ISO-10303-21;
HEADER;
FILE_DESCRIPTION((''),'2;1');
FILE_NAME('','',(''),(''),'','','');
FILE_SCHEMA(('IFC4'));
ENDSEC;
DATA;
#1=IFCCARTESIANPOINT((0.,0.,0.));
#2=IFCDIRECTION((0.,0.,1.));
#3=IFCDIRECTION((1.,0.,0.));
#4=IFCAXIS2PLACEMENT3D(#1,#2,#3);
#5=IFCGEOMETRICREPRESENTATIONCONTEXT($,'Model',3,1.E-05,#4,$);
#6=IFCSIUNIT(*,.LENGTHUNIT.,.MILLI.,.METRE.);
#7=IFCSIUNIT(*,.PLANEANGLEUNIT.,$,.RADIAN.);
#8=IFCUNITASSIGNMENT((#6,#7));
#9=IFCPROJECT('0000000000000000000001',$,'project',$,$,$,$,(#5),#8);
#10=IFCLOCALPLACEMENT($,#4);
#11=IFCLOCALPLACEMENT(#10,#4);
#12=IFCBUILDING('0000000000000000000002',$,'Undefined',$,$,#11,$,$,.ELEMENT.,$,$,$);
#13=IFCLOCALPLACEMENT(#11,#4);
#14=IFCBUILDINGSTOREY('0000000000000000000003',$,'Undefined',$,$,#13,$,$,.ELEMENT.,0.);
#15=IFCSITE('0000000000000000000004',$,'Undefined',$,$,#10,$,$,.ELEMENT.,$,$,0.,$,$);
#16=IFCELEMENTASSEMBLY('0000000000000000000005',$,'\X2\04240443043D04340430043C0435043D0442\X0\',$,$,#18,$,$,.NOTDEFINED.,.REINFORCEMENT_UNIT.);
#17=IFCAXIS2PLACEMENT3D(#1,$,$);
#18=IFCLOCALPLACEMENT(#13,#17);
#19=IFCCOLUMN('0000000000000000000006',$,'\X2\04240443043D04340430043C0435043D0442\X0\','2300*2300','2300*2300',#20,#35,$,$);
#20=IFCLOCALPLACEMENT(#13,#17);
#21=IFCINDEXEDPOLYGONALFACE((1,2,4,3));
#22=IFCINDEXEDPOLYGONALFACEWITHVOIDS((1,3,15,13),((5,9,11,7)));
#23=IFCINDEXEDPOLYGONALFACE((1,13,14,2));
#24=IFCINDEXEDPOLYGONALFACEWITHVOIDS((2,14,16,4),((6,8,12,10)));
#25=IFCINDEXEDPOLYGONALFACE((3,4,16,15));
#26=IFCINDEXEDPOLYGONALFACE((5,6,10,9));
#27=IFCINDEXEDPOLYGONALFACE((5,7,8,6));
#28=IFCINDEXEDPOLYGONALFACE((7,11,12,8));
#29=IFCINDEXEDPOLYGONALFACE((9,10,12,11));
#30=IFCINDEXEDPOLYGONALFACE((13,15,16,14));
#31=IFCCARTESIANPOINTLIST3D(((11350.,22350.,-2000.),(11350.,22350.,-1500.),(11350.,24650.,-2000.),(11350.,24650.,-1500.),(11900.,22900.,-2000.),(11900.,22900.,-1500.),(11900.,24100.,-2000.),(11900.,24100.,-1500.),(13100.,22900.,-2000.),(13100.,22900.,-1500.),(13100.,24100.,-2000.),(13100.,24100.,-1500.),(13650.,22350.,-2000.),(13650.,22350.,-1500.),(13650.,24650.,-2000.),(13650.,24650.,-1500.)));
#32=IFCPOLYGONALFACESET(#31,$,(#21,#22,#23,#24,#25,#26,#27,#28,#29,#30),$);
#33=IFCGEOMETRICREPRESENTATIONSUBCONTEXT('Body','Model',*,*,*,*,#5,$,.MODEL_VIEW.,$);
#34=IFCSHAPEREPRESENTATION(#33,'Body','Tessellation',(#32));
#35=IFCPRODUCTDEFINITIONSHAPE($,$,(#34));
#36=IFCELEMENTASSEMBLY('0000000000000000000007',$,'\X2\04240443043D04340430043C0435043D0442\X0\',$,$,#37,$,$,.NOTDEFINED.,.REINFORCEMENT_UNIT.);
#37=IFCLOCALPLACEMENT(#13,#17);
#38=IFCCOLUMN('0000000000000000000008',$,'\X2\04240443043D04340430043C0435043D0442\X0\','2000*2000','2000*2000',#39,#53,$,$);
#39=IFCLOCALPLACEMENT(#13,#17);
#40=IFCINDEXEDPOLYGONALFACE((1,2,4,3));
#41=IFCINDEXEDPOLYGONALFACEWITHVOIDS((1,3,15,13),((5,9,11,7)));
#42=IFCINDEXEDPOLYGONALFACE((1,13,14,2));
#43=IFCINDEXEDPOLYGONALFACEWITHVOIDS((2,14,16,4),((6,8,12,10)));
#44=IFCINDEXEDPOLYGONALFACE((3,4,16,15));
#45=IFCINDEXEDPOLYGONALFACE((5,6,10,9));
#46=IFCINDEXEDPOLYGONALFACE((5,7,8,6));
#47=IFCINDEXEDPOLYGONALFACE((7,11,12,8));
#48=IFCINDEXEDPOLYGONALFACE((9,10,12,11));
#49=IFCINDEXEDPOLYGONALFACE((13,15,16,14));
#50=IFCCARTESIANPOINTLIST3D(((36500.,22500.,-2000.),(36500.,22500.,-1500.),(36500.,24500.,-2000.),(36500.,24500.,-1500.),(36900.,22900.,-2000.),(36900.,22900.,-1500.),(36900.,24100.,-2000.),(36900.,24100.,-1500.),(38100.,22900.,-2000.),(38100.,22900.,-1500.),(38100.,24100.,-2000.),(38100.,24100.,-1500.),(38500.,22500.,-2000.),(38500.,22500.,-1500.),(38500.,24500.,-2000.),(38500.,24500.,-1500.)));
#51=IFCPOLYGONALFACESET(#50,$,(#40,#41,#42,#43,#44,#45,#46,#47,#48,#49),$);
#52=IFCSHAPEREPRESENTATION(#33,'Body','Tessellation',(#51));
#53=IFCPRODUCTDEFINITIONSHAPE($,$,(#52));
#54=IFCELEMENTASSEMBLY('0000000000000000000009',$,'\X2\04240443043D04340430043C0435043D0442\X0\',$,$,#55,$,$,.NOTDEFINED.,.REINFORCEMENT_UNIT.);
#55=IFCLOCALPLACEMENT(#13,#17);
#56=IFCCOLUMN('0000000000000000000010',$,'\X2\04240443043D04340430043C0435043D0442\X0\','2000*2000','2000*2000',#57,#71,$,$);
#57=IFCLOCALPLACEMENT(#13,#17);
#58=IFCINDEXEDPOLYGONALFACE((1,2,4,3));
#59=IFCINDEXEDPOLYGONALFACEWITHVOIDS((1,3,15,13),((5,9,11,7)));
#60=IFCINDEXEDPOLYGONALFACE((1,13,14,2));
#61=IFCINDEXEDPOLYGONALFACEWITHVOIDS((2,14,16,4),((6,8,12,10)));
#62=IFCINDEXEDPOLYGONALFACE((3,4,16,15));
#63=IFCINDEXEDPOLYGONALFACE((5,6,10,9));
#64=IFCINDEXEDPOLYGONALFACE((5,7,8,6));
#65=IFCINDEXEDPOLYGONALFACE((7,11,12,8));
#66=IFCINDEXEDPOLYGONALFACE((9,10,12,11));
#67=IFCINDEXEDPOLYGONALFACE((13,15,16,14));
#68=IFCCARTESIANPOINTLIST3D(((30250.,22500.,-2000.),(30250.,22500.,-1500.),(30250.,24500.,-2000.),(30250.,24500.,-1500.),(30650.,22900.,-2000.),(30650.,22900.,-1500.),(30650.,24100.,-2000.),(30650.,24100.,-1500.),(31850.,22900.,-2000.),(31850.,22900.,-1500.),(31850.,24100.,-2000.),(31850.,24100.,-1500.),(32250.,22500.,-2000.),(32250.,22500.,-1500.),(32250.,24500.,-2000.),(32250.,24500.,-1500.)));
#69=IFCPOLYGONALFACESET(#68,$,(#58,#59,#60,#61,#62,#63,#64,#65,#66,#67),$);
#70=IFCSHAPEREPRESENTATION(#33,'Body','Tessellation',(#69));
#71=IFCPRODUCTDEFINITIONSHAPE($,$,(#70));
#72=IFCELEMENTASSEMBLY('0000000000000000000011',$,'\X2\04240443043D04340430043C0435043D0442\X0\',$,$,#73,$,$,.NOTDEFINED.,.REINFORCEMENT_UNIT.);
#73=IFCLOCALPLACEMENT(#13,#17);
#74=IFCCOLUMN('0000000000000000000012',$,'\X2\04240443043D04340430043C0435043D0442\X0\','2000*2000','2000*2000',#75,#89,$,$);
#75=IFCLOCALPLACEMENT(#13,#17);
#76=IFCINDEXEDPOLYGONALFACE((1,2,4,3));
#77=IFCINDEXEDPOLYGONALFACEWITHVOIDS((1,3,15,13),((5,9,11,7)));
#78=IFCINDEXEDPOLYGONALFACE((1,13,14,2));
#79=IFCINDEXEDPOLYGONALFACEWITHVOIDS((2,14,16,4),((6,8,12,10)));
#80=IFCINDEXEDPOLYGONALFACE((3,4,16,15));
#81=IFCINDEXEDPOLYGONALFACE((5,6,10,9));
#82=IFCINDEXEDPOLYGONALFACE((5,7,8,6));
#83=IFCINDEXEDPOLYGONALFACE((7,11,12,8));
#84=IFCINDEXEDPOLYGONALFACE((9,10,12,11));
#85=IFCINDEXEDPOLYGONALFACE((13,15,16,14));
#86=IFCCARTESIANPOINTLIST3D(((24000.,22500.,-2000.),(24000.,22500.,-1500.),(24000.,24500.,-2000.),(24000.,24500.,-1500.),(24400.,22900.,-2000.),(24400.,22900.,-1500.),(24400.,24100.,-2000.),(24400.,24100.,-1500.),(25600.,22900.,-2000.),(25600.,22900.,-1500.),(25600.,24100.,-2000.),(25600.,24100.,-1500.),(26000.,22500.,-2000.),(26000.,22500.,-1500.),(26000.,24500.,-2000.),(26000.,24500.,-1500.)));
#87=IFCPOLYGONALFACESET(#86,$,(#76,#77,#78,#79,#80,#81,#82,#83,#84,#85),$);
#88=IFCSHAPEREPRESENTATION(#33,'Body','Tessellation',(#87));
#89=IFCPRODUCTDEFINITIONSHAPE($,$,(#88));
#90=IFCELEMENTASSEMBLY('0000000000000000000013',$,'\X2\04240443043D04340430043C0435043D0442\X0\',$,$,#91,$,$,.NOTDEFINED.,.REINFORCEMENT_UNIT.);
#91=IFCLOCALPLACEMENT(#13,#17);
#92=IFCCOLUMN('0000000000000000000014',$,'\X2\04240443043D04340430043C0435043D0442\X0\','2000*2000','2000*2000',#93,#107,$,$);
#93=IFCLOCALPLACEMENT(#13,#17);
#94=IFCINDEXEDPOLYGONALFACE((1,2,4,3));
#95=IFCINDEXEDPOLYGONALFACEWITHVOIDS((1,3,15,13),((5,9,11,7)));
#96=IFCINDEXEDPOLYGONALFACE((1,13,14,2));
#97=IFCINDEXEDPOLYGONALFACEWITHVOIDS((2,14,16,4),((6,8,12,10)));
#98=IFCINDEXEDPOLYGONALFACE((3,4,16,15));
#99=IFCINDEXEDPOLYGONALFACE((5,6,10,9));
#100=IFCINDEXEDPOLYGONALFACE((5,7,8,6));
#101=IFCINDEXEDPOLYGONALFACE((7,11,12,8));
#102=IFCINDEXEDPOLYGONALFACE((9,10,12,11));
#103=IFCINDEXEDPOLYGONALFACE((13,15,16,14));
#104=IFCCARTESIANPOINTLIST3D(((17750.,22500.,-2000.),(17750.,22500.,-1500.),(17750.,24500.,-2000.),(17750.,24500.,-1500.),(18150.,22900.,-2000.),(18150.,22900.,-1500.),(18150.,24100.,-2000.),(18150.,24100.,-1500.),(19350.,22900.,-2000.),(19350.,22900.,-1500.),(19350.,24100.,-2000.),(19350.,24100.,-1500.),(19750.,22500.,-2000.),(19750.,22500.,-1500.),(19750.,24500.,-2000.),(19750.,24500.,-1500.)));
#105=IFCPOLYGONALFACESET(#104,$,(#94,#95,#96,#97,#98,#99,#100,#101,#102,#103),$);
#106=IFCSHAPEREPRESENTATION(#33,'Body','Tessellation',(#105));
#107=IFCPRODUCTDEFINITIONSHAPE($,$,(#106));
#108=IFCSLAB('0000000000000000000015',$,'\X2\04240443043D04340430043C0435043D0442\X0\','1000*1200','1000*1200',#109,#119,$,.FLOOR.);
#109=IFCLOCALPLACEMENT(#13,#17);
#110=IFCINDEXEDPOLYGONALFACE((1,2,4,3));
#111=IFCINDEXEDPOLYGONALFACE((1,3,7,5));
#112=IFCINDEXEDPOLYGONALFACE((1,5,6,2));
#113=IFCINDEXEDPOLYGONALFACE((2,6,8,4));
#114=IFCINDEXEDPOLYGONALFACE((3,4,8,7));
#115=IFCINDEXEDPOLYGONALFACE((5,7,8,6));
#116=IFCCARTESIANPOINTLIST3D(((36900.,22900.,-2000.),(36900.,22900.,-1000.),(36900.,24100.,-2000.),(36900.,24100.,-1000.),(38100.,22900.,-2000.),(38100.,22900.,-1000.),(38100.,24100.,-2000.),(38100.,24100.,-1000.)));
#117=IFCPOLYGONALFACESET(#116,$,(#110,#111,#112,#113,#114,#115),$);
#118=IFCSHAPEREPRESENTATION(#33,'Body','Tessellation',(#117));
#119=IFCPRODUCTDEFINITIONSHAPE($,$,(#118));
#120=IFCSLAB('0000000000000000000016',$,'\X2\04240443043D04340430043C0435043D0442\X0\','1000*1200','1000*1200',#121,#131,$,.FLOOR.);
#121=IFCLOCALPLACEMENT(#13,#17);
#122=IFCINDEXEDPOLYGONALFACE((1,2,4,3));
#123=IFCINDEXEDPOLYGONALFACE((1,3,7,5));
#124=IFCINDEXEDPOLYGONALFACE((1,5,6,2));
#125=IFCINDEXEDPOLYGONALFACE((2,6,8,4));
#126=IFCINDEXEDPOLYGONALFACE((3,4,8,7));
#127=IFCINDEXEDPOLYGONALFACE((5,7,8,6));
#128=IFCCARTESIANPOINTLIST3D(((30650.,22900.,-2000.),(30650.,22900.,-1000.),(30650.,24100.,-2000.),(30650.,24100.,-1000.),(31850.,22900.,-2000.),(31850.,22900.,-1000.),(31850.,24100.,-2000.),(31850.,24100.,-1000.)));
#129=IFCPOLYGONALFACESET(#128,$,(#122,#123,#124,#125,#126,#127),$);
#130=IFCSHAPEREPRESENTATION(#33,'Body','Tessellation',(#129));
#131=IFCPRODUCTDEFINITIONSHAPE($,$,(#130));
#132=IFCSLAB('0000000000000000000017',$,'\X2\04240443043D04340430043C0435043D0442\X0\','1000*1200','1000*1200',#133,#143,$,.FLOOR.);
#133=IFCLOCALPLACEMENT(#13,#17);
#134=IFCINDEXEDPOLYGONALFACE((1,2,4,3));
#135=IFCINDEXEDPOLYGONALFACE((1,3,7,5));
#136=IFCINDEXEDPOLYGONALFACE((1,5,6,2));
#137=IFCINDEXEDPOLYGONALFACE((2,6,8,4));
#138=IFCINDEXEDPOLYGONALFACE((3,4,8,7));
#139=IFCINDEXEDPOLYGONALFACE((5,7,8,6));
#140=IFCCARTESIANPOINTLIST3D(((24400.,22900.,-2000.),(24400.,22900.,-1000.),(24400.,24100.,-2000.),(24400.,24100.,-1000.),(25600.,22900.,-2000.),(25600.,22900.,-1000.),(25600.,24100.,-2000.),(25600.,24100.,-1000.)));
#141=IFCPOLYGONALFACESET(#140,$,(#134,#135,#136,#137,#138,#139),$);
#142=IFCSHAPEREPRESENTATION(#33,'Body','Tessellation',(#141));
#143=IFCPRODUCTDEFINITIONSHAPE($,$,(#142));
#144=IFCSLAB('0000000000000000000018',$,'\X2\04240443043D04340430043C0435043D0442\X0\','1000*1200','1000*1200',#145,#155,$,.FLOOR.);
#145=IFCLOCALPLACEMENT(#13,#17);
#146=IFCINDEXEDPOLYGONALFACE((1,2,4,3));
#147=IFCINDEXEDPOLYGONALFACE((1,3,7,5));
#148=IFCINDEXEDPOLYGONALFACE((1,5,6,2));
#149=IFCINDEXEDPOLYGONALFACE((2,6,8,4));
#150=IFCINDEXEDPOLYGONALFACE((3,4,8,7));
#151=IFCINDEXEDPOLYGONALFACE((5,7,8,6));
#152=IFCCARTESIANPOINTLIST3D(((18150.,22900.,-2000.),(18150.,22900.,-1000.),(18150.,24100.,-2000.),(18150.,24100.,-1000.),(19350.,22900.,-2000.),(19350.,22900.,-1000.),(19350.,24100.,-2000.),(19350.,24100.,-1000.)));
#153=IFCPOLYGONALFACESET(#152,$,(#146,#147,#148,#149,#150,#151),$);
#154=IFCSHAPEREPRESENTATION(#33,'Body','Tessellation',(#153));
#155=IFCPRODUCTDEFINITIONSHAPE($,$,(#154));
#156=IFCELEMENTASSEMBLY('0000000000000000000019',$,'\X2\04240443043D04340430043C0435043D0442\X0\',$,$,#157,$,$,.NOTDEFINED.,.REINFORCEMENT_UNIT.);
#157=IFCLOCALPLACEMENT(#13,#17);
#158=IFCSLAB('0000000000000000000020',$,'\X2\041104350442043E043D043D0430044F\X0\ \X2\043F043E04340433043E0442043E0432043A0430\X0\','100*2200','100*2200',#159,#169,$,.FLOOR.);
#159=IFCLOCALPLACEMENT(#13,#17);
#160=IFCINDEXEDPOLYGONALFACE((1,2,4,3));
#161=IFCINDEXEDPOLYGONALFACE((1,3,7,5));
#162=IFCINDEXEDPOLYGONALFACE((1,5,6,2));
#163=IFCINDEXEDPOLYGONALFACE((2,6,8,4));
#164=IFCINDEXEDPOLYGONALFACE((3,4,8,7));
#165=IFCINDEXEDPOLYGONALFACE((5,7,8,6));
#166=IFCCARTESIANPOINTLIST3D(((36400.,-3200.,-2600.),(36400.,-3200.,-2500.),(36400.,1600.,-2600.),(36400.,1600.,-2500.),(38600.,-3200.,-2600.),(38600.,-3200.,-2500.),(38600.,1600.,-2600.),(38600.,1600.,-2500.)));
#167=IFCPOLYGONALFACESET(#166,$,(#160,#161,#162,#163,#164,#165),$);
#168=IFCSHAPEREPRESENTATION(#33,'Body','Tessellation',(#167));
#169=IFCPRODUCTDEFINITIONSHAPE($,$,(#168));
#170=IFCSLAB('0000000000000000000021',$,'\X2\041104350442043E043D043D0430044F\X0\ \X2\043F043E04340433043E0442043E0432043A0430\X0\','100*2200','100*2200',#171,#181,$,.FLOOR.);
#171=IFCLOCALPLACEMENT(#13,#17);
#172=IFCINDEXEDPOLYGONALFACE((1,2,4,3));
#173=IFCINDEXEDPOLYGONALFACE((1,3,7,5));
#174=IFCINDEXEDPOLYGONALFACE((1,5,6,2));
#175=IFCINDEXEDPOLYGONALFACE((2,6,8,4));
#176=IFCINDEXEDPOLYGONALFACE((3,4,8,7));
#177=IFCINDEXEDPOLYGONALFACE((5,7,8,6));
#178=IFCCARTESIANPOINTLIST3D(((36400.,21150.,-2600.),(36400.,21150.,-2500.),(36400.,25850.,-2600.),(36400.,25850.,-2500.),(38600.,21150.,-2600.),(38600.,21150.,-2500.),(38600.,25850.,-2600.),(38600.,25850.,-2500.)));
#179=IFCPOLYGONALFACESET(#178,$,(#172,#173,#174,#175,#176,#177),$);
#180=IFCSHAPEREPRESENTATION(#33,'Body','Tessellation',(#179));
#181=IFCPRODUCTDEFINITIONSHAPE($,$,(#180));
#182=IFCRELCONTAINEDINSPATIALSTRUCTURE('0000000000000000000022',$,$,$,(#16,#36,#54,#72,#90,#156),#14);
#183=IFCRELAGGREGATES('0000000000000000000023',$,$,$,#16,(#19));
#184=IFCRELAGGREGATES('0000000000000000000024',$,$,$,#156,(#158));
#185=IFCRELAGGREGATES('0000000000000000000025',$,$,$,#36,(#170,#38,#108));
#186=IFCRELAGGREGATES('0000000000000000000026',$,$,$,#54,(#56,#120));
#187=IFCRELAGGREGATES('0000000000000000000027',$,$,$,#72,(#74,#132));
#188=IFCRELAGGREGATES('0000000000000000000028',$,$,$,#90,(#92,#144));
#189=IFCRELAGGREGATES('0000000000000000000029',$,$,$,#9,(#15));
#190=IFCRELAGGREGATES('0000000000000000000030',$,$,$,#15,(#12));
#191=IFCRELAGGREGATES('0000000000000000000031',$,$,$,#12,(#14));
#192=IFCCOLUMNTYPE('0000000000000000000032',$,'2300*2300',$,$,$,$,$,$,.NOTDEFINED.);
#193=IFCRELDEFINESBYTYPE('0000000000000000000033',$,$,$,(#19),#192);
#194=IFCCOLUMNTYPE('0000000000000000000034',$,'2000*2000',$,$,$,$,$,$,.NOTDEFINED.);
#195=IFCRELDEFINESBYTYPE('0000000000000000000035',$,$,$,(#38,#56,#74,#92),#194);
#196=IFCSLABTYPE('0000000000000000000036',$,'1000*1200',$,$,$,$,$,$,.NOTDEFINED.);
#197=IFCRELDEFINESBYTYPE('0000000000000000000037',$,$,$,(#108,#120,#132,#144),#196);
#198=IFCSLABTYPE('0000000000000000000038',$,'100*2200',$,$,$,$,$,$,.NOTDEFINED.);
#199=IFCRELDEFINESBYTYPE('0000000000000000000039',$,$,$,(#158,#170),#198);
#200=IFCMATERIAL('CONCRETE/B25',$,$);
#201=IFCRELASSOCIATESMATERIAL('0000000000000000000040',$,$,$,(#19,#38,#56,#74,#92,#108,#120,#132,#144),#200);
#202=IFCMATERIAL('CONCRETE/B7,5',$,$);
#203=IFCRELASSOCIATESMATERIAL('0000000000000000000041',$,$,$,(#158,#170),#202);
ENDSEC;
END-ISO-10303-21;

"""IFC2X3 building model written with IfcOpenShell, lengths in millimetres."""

from ifc_helpers import new_model, si_unit, frame, origin_with_axes, origin_2d_with_axis, place, context, subcontext, project, spatial, polyline, rectangle, outline, extrude, boolean, material, type_object, element, aggregate, save


model = new_model("IFC2X3")

# Units and contexts
model_context = context("Model", 3, precision=1e-05, world=origin_with_axes())
body_context = subcontext(model_context, "Body", "Model", "MODEL_VIEW")
ifc_project = project(units=[si_unit("LENGTHUNIT", "METRE", prefix="MILLI"), si_unit("PLANEANGLEUNIT", "RADIAN")], contexts=[model_context])

# Site, building, storey
site_placement = place(None, origin_with_axes())
site = spatial("IfcSite", under=ifc_project, at=site_placement, Name="Undefined", CompositionType="ELEMENT", RefElevation=0.0)
building_placement = place(site_placement, origin_with_axes())
building = spatial("IfcBuilding", under=site, at=building_placement, Name="Undefined", CompositionType="ELEMENT")
storey_placement = place(building_placement, origin_with_axes())
storey = spatial("IfcBuildingStorey", under=building, at=storey_placement, Name="Undefined", CompositionType="ELEMENT", Elevation=0.0)

# Element assemblies, columns
assembly_1_placement = place(storey_placement, origin_with_axes())
assembly_1 = element("IfcElementAssembly", 1, at=assembly_1_placement, inside=storey, Name="Фундамент", AssemblyPlace="NOTDEFINED", PredefinedType="REINFORCEMENT_UNIT")
ifc_material_1 = material(Name="CONCRETE/B25")
column_type_1 = type_object("IfcColumnType", Name="2300*2300", PredefinedType="NOTDEFINED")
column_1_placement = place(assembly_1_placement, frame((12500.0, 23500.0, -2000.0), z_axis=(0.0, 0.0, 1.0), x_axis=(0.0, -1.0, 0.0)))
column_1 = element("IfcColumn", 2, at=column_1_placement, type_object=column_type_1, material=ifc_material_1, Name="Фундамент", Description="2300*2300", ObjectType="2300*2300", context=body_context, shape_type="CSG", body=[
    boolean("DIFFERENCE", extrude(rectangle(XDim=2300.0, YDim=2300.0, at=origin_2d_with_axis()), frame((0.0, 0.0, 500.0), z_axis=(0.0, 0.0, -1.0), x_axis=(0.0, 1.0, 0.0)), (0.0, 0.0, 1.0), 500.0), extrude(outline(polyline([(0.0, 0.0), (1200.0, 0.0), (1200.0, 1200.0), (0.0, 1200.0), (0.0, 0.0)])), frame((-600.0, -600.0, -100.0), z_axis=(0.0, 0.0, 1.0), x_axis=(1.0, 0.0, 0.0)), (0.0, 0.0, 1.0), 700.0)),
])
aggregate(assembly_1, [column_1])
assembly_2_placement = place(storey_placement, origin_with_axes())
assembly_2 = element("IfcElementAssembly", 3, at=assembly_2_placement, inside=storey, Name="Фундамент", AssemblyPlace="NOTDEFINED", PredefinedType="REINFORCEMENT_UNIT")
column_type_2 = type_object("IfcColumnType", Name="2000*2000", PredefinedType="NOTDEFINED")
column_2_placement = place(assembly_2_placement, frame((37500.0, 23500.0, -2000.0), z_axis=(0.0, 0.0, 1.0), x_axis=(0.0, -1.0, 0.0)))
column_2 = element("IfcColumn", 4, at=column_2_placement, type_object=column_type_2, material=ifc_material_1, Name="Фундамент", Description="2000*2000", ObjectType="2000*2000", context=body_context, shape_type="CSG", body=[
    boolean("DIFFERENCE", extrude(rectangle(XDim=2000.0, YDim=2000.0, at=origin_2d_with_axis()), frame((0.0, 0.0, 500.0), z_axis=(0.0, 0.0, -1.0), x_axis=(0.0, 1.0, 0.0)), (0.0, 0.0, 1.0), 500.0), extrude(outline(polyline([(0.0, 0.0), (1200.0, 0.0), (1200.0, 1200.0), (0.0, 1200.0), (0.0, 0.0)])), frame((-600.0, -600.0, -100.0), z_axis=(0.0, 0.0, 1.0), x_axis=(1.0, 0.0, 0.0)), (0.0, 0.0, 1.0), 700.0)),
])
assembly_3_placement = place(storey_placement, origin_with_axes())
assembly_3 = element("IfcElementAssembly", 5, at=assembly_3_placement, inside=storey, Name="Фундамент", AssemblyPlace="NOTDEFINED", PredefinedType="REINFORCEMENT_UNIT")
column_3_placement = place(assembly_3_placement, frame((31250.0, 23500.0, -2000.0), z_axis=(0.0, 0.0, 1.0), x_axis=(0.0, -1.0, 0.0)))
column_3 = element("IfcColumn", 6, at=column_3_placement, type_object=column_type_2, material=ifc_material_1, Name="Фундамент", Description="2000*2000", ObjectType="2000*2000", context=body_context, shape_type="CSG", body=[
    boolean("DIFFERENCE", extrude(rectangle(XDim=2000.0, YDim=2000.0, at=origin_2d_with_axis()), frame((0.0, 0.0, 500.0), z_axis=(0.0, 0.0, -1.0), x_axis=(0.0, 1.0, 0.0)), (0.0, 0.0, 1.0), 500.0), extrude(outline(polyline([(0.0, 0.0), (1200.0, 0.0), (1200.0, 1200.0), (0.0, 1200.0), (0.0, 0.0)])), frame((-600.0, -600.0, -100.0), z_axis=(0.0, 0.0, 1.0), x_axis=(1.0, 0.0, 0.0)), (0.0, 0.0, 1.0), 700.0)),
])
assembly_4_placement = place(storey_placement, origin_with_axes())
assembly_4 = element("IfcElementAssembly", 7, at=assembly_4_placement, inside=storey, Name="Фундамент", AssemblyPlace="NOTDEFINED", PredefinedType="REINFORCEMENT_UNIT")
column_4_placement = place(assembly_4_placement, frame((25000.0, 23500.0, -2000.0), z_axis=(0.0, 0.0, 1.0), x_axis=(0.0, -1.0, 0.0)))
column_4 = element("IfcColumn", 8, at=column_4_placement, type_object=column_type_2, material=ifc_material_1, Name="Фундамент", Description="2000*2000", ObjectType="2000*2000", context=body_context, shape_type="CSG", body=[
    boolean("DIFFERENCE", extrude(rectangle(XDim=2000.0, YDim=2000.0, at=origin_2d_with_axis()), frame((0.0, 0.0, 500.0), z_axis=(0.0, 0.0, -1.0), x_axis=(0.0, 1.0, 0.0)), (0.0, 0.0, 1.0), 500.0), extrude(outline(polyline([(0.0, 0.0), (1200.0, 0.0), (1200.0, 1200.0), (0.0, 1200.0), (0.0, 0.0)])), frame((-600.0, -600.0, -100.0), z_axis=(0.0, 0.0, 1.0), x_axis=(1.0, 0.0, 0.0)), (0.0, 0.0, 1.0), 700.0)),
])
assembly_5_placement = place(storey_placement, origin_with_axes())
assembly_5 = element("IfcElementAssembly", 9, at=assembly_5_placement, inside=storey, Name="Фундамент", AssemblyPlace="NOTDEFINED", PredefinedType="REINFORCEMENT_UNIT")
column_5_placement = place(assembly_5_placement, frame((18750.0, 23500.0, -2000.0), z_axis=(0.0, 0.0, 1.0), x_axis=(0.0, -1.0, 0.0)))
column_5 = element("IfcColumn", 10, at=column_5_placement, type_object=column_type_2, material=ifc_material_1, Name="Фундамент", Description="2000*2000", ObjectType="2000*2000", context=body_context, shape_type="CSG", body=[
    boolean("DIFFERENCE", extrude(rectangle(XDim=2000.0, YDim=2000.0, at=origin_2d_with_axis()), frame((0.0, 0.0, 500.0), z_axis=(0.0, 0.0, -1.0), x_axis=(0.0, 1.0, 0.0)), (0.0, 0.0, 1.0), 500.0), extrude(outline(polyline([(0.0, 0.0), (1200.0, 0.0), (1200.0, 1200.0), (0.0, 1200.0), (0.0, 0.0)])), frame((-600.0, -600.0, -100.0), z_axis=(0.0, 0.0, 1.0), x_axis=(1.0, 0.0, 0.0)), (0.0, 0.0, 1.0), 700.0)),
])

# Slabs
slab_type_1 = type_object("IfcSlabType", Name="1000*1200", PredefinedType="NOTDEFINED")
slab_1_placement = place(assembly_2_placement, frame((36900.0, 24100.0, -1500.0), z_axis=(0.0, 0.0, 1.0), x_axis=(0.0, -1.0, 0.0)))
slab_1 = element("IfcSlab", 11, at=slab_1_placement, type_object=slab_type_1, material=ifc_material_1, Name="Фундамент", Description="1000*1200", ObjectType="1000*1200", PredefinedType="FLOOR", context=body_context, shape_type="SweptSolid", body=[
    extrude(outline(polyline([(0.0, 0.0), (1200.0, 0.0), (1200.0, 1200.0), (0.0, 1200.0), (0.0, 0.0)])), frame((0.0, 0.0, -500.0), z_axis=(0.0, 0.0, 1.0), x_axis=(1.0, 0.0, 0.0)), (0.0, 0.0, 1.0), 1000.0),
])
slab_2_placement = place(assembly_3_placement, frame((30650.0, 24100.0, -1500.0), z_axis=(0.0, 0.0, 1.0), x_axis=(0.0, -1.0, 0.0)))
slab_2 = element("IfcSlab", 12, at=slab_2_placement, type_object=slab_type_1, material=ifc_material_1, Name="Фундамент", Description="1000*1200", ObjectType="1000*1200", PredefinedType="FLOOR", context=body_context, shape_type="SweptSolid", body=[
    extrude(outline(polyline([(0.0, 0.0), (1200.0, 0.0), (1200.0, 1200.0), (0.0, 1200.0), (0.0, 0.0)])), frame((0.0, 0.0, -500.0), z_axis=(0.0, 0.0, 1.0), x_axis=(1.0, 0.0, 0.0)), (0.0, 0.0, 1.0), 1000.0),
])
slab_3_placement = place(assembly_4_placement, frame((24400.0, 24100.0, -1500.0), z_axis=(0.0, 0.0, 1.0), x_axis=(0.0, -1.0, 0.0)))
slab_3 = element("IfcSlab", 13, at=slab_3_placement, type_object=slab_type_1, material=ifc_material_1, Name="Фундамент", Description="1000*1200", ObjectType="1000*1200", PredefinedType="FLOOR", context=body_context, shape_type="SweptSolid", body=[
    extrude(outline(polyline([(0.0, 0.0), (1200.0, 0.0), (1200.0, 1200.0), (0.0, 1200.0), (0.0, 0.0)])), frame((0.0, 0.0, -500.0), z_axis=(0.0, 0.0, 1.0), x_axis=(1.0, 0.0, 0.0)), (0.0, 0.0, 1.0), 1000.0),
])
slab_4_placement = place(assembly_5_placement, frame((18150.0, 24100.0, -1500.0), z_axis=(0.0, 0.0, 1.0), x_axis=(0.0, -1.0, 0.0)))
slab_4 = element("IfcSlab", 14, at=slab_4_placement, type_object=slab_type_1, material=ifc_material_1, Name="Фундамент", Description="1000*1200", ObjectType="1000*1200", PredefinedType="FLOOR", context=body_context, shape_type="SweptSolid", body=[
    extrude(outline(polyline([(0.0, 0.0), (1200.0, 0.0), (1200.0, 1200.0), (0.0, 1200.0), (0.0, 0.0)])), frame((0.0, 0.0, -500.0), z_axis=(0.0, 0.0, 1.0), x_axis=(1.0, 0.0, 0.0)), (0.0, 0.0, 1.0), 1000.0),
])

# Element assembly, slab
assembly_6_placement = place(storey_placement, origin_with_axes())
assembly_6 = element("IfcElementAssembly", 15, at=assembly_6_placement, inside=storey, Name="Фундамент", AssemblyPlace="NOTDEFINED", PredefinedType="REINFORCEMENT_UNIT")
ifc_material_2 = material(Name="CONCRETE/B7,5")
slab_type_2 = type_object("IfcSlabType", Name="100*2200", PredefinedType="NOTDEFINED")
slab_5_placement = place(assembly_6_placement, frame((36400.0, 1600.0, -2550.0), z_axis=(0.0, 0.0, 1.0), x_axis=(0.0, -1.0, 0.0)))
slab_5 = element("IfcSlab", 16, at=slab_5_placement, type_object=slab_type_2, material=ifc_material_2, Name="Бетонная подготовка", Description="100*2200", ObjectType="100*2200", PredefinedType="FLOOR", context=body_context, shape_type="SweptSolid", body=[
    extrude(outline(polyline([(0.0, 0.0), (4800.0, 0.0), (4800.0, 2200.0), (0.0, 2200.0), (0.0, 0.0)])), frame((0.0, 0.0, -50.0), z_axis=(0.0, 0.0, 1.0), x_axis=(1.0, 0.0, 0.0)), (0.0, 0.0, 1.0), 100.0),
])

# Slab
slab_6_placement = place(assembly_2_placement, frame((36400.0, 25850.0, -2550.0), z_axis=(0.0, 0.0, 1.0), x_axis=(0.0, -1.0, 0.0)))
slab_6 = element("IfcSlab", 17, at=slab_6_placement, type_object=slab_type_2, material=ifc_material_2, Name="Бетонная подготовка", Description="100*2200", ObjectType="100*2200", PredefinedType="FLOOR", context=body_context, shape_type="SweptSolid", body=[
    extrude(outline(polyline([(0.0, 0.0), (4700.0, 0.0), (4700.0, 2200.0), (0.0, 2200.0), (0.0, 0.0)])), frame((0.0, 0.0, -50.0), z_axis=(0.0, 0.0, 1.0), x_axis=(1.0, 0.0, 0.0)), (0.0, 0.0, 1.0), 100.0),
])

aggregate(assembly_6, [slab_5])
aggregate(assembly_2, [slab_6, column_2, slab_1])
aggregate(assembly_3, [column_3, slab_2])
aggregate(assembly_4, [column_4, slab_3])
aggregate(assembly_5, [column_5, slab_4])

save(model, "model.ifc")
